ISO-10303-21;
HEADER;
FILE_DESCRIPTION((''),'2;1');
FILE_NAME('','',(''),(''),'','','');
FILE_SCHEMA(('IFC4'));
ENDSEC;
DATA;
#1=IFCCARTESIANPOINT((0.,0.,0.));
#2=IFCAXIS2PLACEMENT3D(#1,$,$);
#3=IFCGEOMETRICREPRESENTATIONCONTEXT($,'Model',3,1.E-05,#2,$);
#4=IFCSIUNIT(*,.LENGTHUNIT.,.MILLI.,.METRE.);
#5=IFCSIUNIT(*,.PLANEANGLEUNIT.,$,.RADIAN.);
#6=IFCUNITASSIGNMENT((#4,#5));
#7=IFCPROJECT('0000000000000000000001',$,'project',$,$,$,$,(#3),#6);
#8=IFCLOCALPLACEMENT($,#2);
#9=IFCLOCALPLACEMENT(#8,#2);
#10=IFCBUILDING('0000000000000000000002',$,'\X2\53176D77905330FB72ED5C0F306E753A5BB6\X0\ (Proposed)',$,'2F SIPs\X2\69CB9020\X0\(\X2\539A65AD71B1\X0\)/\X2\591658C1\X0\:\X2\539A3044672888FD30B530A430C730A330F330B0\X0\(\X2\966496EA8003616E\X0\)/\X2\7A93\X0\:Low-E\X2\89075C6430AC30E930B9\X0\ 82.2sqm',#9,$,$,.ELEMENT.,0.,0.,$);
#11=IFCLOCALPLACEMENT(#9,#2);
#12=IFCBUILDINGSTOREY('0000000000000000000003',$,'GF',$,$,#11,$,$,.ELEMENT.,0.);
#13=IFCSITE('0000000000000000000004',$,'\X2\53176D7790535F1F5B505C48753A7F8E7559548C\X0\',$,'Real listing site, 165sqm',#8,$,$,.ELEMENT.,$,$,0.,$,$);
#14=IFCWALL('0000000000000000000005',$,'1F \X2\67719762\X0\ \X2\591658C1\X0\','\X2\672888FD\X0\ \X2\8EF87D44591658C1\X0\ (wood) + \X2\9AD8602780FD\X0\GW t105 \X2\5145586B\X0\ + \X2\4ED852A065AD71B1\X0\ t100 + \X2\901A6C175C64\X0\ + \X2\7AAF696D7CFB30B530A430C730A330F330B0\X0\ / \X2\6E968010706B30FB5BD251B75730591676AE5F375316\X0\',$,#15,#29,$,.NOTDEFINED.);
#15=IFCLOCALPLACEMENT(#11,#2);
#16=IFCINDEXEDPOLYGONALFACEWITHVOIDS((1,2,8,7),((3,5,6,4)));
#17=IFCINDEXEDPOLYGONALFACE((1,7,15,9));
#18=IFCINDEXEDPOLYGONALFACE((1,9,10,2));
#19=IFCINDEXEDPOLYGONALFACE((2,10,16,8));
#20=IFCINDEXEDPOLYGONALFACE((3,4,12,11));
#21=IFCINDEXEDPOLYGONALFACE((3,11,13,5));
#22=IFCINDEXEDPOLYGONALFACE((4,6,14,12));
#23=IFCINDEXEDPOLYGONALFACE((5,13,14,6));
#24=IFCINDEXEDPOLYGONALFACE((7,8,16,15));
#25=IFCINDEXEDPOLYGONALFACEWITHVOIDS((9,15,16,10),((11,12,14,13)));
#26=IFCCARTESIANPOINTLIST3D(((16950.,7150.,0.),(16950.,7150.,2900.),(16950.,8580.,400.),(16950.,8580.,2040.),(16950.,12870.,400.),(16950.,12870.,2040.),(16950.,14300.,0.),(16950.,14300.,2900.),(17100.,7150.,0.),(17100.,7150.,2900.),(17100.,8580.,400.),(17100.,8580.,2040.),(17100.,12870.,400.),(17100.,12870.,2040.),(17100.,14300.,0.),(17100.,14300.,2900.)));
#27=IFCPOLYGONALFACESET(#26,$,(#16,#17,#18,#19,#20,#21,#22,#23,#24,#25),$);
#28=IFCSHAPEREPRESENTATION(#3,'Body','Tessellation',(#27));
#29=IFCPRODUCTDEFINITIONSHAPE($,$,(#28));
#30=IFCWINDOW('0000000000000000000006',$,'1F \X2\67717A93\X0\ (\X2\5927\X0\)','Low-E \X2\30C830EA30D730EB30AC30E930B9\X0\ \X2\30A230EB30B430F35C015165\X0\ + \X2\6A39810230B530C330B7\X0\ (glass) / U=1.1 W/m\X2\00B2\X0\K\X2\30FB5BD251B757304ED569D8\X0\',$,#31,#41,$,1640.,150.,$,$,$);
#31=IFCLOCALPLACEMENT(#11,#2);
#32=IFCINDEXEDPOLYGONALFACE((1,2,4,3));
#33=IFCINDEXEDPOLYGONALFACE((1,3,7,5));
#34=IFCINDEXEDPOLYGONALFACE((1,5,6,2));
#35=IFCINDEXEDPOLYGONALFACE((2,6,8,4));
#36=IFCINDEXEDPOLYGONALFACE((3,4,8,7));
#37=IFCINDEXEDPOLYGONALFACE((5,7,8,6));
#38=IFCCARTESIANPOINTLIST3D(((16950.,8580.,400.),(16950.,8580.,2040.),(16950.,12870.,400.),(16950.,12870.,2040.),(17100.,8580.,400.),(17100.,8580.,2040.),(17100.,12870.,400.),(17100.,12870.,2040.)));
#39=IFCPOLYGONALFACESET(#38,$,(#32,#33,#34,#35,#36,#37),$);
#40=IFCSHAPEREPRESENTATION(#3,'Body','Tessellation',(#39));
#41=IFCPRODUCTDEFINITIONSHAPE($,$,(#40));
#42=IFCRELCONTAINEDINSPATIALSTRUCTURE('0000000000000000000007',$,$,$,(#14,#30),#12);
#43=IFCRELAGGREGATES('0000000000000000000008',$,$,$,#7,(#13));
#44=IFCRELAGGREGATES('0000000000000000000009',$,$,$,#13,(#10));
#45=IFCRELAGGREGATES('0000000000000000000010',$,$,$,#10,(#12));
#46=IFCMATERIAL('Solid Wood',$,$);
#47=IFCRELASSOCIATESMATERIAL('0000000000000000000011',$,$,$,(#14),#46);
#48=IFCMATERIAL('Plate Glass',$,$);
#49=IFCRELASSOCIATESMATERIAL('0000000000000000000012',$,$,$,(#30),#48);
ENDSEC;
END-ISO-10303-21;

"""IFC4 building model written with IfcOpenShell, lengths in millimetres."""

from ifc_helpers import new_model, si_unit, frame, frame_2d, origin, place, context, project, spatial, rectangle, extrude, material, element, fill, save


model = new_model("IFC4")

# Units and contexts
model_context = context("Model", 3, precision=1e-05, world=origin())
ifc_project = project(units=[si_unit("LENGTHUNIT", "METRE", prefix="MILLI"), si_unit("PLANEANGLEUNIT", "RADIAN")], contexts=[model_context])

# Site, building, storey
site_placement = place(None, origin())
site = spatial("IfcSite", under=ifc_project, at=site_placement, Name="北海道弟子屈町美留和", ObjectType="Real listing site, 165sqm", CompositionType="ELEMENT", RefElevation=0.0)
building_placement = place(site_placement, origin())
building = spatial("IfcBuilding", under=site, at=building_placement, Name="北海道・狭小の町家 (Proposed)", ObjectType="2F SIPs構造(厚断熱)/外壁:厚い木製サイディング(除雪考慮)/窓:Low-E複層ガラス 82.2sqm", CompositionType="ELEMENT", ElevationOfRefHeight=0.0, ElevationOfTerrain=0.0)
storey_placement = place(building_placement, origin())
storey = spatial("IfcBuildingStorey", under=building, at=storey_placement, Name="GF", CompositionType="ELEMENT", Elevation=0.0)

# Shared definitions
ifc_material_1 = material(Name="Solid Wood")

# Wall, opening, window
wall_1_placement = place(storey_placement, frame((8475.0, 3575.0, 0.0)))
wall_1 = element("IfcWall", 1, at=wall_1_placement, inside=storey, material=ifc_material_1, Name="1F 東面 外壁", Description="木製 軸組外壁 (wood) + 高性能GW t105 充填 + 付加断熱 t100 + 通気層 + 窯業系サイディング / 準耐火・寒冷地外皮強化", PredefinedType="NOTDEFINED", context=model_context, shape_type="SweptSolid", body=[
    extrude(rectangle(XDim=150.0, YDim=7150.0, at=frame_2d((75.0, 3575.0))), frame((8475.0, 3575.0, 0.0)), (0.0, 0.0, 1.0), 2900.0),
])
opening_1_placement = place(storey_placement, frame((8475.0, 4290.0, 200.0)))
opening_1 = element("IfcOpeningElement", 2, at=opening_1_placement, cuts=wall_1, PredefinedType="NOTDEFINED", context=model_context, shape_type="SweptSolid", body=[
    extrude(rectangle(XDim=150.0, YDim=4290.0, at=frame_2d((75.0, 2145.0))), frame((8475.0, 4290.0, 200.0)), (0.0, 0.0, 1.0), 1640.0),
])
ifc_material_2 = material(Name="Plate Glass")
window_1_placement = place(storey_placement, frame((8475.0, 4290.0, 200.0)))
window_1 = element("IfcWindow", 3, at=window_1_placement, inside=storey, material=ifc_material_2, Name="1F 東窓 (大)", Description="Low-E トリプルガラス アルゴン封入 + 樹脂サッシ (glass) / U=1.1 W/m²K・寒冷地仕様", OverallHeight=1640.0, OverallWidth=150.0, context=model_context, shape_type="SweptSolid", body=[
    extrude(rectangle(XDim=150.0, YDim=4290.0, at=frame_2d((75.0, 2145.0))), frame((8475.0, 4290.0, 200.0)), (0.0, 0.0, 1.0), 1640.0),
])
fill(opening_1, window_1)

save(model, "model.ifc")
